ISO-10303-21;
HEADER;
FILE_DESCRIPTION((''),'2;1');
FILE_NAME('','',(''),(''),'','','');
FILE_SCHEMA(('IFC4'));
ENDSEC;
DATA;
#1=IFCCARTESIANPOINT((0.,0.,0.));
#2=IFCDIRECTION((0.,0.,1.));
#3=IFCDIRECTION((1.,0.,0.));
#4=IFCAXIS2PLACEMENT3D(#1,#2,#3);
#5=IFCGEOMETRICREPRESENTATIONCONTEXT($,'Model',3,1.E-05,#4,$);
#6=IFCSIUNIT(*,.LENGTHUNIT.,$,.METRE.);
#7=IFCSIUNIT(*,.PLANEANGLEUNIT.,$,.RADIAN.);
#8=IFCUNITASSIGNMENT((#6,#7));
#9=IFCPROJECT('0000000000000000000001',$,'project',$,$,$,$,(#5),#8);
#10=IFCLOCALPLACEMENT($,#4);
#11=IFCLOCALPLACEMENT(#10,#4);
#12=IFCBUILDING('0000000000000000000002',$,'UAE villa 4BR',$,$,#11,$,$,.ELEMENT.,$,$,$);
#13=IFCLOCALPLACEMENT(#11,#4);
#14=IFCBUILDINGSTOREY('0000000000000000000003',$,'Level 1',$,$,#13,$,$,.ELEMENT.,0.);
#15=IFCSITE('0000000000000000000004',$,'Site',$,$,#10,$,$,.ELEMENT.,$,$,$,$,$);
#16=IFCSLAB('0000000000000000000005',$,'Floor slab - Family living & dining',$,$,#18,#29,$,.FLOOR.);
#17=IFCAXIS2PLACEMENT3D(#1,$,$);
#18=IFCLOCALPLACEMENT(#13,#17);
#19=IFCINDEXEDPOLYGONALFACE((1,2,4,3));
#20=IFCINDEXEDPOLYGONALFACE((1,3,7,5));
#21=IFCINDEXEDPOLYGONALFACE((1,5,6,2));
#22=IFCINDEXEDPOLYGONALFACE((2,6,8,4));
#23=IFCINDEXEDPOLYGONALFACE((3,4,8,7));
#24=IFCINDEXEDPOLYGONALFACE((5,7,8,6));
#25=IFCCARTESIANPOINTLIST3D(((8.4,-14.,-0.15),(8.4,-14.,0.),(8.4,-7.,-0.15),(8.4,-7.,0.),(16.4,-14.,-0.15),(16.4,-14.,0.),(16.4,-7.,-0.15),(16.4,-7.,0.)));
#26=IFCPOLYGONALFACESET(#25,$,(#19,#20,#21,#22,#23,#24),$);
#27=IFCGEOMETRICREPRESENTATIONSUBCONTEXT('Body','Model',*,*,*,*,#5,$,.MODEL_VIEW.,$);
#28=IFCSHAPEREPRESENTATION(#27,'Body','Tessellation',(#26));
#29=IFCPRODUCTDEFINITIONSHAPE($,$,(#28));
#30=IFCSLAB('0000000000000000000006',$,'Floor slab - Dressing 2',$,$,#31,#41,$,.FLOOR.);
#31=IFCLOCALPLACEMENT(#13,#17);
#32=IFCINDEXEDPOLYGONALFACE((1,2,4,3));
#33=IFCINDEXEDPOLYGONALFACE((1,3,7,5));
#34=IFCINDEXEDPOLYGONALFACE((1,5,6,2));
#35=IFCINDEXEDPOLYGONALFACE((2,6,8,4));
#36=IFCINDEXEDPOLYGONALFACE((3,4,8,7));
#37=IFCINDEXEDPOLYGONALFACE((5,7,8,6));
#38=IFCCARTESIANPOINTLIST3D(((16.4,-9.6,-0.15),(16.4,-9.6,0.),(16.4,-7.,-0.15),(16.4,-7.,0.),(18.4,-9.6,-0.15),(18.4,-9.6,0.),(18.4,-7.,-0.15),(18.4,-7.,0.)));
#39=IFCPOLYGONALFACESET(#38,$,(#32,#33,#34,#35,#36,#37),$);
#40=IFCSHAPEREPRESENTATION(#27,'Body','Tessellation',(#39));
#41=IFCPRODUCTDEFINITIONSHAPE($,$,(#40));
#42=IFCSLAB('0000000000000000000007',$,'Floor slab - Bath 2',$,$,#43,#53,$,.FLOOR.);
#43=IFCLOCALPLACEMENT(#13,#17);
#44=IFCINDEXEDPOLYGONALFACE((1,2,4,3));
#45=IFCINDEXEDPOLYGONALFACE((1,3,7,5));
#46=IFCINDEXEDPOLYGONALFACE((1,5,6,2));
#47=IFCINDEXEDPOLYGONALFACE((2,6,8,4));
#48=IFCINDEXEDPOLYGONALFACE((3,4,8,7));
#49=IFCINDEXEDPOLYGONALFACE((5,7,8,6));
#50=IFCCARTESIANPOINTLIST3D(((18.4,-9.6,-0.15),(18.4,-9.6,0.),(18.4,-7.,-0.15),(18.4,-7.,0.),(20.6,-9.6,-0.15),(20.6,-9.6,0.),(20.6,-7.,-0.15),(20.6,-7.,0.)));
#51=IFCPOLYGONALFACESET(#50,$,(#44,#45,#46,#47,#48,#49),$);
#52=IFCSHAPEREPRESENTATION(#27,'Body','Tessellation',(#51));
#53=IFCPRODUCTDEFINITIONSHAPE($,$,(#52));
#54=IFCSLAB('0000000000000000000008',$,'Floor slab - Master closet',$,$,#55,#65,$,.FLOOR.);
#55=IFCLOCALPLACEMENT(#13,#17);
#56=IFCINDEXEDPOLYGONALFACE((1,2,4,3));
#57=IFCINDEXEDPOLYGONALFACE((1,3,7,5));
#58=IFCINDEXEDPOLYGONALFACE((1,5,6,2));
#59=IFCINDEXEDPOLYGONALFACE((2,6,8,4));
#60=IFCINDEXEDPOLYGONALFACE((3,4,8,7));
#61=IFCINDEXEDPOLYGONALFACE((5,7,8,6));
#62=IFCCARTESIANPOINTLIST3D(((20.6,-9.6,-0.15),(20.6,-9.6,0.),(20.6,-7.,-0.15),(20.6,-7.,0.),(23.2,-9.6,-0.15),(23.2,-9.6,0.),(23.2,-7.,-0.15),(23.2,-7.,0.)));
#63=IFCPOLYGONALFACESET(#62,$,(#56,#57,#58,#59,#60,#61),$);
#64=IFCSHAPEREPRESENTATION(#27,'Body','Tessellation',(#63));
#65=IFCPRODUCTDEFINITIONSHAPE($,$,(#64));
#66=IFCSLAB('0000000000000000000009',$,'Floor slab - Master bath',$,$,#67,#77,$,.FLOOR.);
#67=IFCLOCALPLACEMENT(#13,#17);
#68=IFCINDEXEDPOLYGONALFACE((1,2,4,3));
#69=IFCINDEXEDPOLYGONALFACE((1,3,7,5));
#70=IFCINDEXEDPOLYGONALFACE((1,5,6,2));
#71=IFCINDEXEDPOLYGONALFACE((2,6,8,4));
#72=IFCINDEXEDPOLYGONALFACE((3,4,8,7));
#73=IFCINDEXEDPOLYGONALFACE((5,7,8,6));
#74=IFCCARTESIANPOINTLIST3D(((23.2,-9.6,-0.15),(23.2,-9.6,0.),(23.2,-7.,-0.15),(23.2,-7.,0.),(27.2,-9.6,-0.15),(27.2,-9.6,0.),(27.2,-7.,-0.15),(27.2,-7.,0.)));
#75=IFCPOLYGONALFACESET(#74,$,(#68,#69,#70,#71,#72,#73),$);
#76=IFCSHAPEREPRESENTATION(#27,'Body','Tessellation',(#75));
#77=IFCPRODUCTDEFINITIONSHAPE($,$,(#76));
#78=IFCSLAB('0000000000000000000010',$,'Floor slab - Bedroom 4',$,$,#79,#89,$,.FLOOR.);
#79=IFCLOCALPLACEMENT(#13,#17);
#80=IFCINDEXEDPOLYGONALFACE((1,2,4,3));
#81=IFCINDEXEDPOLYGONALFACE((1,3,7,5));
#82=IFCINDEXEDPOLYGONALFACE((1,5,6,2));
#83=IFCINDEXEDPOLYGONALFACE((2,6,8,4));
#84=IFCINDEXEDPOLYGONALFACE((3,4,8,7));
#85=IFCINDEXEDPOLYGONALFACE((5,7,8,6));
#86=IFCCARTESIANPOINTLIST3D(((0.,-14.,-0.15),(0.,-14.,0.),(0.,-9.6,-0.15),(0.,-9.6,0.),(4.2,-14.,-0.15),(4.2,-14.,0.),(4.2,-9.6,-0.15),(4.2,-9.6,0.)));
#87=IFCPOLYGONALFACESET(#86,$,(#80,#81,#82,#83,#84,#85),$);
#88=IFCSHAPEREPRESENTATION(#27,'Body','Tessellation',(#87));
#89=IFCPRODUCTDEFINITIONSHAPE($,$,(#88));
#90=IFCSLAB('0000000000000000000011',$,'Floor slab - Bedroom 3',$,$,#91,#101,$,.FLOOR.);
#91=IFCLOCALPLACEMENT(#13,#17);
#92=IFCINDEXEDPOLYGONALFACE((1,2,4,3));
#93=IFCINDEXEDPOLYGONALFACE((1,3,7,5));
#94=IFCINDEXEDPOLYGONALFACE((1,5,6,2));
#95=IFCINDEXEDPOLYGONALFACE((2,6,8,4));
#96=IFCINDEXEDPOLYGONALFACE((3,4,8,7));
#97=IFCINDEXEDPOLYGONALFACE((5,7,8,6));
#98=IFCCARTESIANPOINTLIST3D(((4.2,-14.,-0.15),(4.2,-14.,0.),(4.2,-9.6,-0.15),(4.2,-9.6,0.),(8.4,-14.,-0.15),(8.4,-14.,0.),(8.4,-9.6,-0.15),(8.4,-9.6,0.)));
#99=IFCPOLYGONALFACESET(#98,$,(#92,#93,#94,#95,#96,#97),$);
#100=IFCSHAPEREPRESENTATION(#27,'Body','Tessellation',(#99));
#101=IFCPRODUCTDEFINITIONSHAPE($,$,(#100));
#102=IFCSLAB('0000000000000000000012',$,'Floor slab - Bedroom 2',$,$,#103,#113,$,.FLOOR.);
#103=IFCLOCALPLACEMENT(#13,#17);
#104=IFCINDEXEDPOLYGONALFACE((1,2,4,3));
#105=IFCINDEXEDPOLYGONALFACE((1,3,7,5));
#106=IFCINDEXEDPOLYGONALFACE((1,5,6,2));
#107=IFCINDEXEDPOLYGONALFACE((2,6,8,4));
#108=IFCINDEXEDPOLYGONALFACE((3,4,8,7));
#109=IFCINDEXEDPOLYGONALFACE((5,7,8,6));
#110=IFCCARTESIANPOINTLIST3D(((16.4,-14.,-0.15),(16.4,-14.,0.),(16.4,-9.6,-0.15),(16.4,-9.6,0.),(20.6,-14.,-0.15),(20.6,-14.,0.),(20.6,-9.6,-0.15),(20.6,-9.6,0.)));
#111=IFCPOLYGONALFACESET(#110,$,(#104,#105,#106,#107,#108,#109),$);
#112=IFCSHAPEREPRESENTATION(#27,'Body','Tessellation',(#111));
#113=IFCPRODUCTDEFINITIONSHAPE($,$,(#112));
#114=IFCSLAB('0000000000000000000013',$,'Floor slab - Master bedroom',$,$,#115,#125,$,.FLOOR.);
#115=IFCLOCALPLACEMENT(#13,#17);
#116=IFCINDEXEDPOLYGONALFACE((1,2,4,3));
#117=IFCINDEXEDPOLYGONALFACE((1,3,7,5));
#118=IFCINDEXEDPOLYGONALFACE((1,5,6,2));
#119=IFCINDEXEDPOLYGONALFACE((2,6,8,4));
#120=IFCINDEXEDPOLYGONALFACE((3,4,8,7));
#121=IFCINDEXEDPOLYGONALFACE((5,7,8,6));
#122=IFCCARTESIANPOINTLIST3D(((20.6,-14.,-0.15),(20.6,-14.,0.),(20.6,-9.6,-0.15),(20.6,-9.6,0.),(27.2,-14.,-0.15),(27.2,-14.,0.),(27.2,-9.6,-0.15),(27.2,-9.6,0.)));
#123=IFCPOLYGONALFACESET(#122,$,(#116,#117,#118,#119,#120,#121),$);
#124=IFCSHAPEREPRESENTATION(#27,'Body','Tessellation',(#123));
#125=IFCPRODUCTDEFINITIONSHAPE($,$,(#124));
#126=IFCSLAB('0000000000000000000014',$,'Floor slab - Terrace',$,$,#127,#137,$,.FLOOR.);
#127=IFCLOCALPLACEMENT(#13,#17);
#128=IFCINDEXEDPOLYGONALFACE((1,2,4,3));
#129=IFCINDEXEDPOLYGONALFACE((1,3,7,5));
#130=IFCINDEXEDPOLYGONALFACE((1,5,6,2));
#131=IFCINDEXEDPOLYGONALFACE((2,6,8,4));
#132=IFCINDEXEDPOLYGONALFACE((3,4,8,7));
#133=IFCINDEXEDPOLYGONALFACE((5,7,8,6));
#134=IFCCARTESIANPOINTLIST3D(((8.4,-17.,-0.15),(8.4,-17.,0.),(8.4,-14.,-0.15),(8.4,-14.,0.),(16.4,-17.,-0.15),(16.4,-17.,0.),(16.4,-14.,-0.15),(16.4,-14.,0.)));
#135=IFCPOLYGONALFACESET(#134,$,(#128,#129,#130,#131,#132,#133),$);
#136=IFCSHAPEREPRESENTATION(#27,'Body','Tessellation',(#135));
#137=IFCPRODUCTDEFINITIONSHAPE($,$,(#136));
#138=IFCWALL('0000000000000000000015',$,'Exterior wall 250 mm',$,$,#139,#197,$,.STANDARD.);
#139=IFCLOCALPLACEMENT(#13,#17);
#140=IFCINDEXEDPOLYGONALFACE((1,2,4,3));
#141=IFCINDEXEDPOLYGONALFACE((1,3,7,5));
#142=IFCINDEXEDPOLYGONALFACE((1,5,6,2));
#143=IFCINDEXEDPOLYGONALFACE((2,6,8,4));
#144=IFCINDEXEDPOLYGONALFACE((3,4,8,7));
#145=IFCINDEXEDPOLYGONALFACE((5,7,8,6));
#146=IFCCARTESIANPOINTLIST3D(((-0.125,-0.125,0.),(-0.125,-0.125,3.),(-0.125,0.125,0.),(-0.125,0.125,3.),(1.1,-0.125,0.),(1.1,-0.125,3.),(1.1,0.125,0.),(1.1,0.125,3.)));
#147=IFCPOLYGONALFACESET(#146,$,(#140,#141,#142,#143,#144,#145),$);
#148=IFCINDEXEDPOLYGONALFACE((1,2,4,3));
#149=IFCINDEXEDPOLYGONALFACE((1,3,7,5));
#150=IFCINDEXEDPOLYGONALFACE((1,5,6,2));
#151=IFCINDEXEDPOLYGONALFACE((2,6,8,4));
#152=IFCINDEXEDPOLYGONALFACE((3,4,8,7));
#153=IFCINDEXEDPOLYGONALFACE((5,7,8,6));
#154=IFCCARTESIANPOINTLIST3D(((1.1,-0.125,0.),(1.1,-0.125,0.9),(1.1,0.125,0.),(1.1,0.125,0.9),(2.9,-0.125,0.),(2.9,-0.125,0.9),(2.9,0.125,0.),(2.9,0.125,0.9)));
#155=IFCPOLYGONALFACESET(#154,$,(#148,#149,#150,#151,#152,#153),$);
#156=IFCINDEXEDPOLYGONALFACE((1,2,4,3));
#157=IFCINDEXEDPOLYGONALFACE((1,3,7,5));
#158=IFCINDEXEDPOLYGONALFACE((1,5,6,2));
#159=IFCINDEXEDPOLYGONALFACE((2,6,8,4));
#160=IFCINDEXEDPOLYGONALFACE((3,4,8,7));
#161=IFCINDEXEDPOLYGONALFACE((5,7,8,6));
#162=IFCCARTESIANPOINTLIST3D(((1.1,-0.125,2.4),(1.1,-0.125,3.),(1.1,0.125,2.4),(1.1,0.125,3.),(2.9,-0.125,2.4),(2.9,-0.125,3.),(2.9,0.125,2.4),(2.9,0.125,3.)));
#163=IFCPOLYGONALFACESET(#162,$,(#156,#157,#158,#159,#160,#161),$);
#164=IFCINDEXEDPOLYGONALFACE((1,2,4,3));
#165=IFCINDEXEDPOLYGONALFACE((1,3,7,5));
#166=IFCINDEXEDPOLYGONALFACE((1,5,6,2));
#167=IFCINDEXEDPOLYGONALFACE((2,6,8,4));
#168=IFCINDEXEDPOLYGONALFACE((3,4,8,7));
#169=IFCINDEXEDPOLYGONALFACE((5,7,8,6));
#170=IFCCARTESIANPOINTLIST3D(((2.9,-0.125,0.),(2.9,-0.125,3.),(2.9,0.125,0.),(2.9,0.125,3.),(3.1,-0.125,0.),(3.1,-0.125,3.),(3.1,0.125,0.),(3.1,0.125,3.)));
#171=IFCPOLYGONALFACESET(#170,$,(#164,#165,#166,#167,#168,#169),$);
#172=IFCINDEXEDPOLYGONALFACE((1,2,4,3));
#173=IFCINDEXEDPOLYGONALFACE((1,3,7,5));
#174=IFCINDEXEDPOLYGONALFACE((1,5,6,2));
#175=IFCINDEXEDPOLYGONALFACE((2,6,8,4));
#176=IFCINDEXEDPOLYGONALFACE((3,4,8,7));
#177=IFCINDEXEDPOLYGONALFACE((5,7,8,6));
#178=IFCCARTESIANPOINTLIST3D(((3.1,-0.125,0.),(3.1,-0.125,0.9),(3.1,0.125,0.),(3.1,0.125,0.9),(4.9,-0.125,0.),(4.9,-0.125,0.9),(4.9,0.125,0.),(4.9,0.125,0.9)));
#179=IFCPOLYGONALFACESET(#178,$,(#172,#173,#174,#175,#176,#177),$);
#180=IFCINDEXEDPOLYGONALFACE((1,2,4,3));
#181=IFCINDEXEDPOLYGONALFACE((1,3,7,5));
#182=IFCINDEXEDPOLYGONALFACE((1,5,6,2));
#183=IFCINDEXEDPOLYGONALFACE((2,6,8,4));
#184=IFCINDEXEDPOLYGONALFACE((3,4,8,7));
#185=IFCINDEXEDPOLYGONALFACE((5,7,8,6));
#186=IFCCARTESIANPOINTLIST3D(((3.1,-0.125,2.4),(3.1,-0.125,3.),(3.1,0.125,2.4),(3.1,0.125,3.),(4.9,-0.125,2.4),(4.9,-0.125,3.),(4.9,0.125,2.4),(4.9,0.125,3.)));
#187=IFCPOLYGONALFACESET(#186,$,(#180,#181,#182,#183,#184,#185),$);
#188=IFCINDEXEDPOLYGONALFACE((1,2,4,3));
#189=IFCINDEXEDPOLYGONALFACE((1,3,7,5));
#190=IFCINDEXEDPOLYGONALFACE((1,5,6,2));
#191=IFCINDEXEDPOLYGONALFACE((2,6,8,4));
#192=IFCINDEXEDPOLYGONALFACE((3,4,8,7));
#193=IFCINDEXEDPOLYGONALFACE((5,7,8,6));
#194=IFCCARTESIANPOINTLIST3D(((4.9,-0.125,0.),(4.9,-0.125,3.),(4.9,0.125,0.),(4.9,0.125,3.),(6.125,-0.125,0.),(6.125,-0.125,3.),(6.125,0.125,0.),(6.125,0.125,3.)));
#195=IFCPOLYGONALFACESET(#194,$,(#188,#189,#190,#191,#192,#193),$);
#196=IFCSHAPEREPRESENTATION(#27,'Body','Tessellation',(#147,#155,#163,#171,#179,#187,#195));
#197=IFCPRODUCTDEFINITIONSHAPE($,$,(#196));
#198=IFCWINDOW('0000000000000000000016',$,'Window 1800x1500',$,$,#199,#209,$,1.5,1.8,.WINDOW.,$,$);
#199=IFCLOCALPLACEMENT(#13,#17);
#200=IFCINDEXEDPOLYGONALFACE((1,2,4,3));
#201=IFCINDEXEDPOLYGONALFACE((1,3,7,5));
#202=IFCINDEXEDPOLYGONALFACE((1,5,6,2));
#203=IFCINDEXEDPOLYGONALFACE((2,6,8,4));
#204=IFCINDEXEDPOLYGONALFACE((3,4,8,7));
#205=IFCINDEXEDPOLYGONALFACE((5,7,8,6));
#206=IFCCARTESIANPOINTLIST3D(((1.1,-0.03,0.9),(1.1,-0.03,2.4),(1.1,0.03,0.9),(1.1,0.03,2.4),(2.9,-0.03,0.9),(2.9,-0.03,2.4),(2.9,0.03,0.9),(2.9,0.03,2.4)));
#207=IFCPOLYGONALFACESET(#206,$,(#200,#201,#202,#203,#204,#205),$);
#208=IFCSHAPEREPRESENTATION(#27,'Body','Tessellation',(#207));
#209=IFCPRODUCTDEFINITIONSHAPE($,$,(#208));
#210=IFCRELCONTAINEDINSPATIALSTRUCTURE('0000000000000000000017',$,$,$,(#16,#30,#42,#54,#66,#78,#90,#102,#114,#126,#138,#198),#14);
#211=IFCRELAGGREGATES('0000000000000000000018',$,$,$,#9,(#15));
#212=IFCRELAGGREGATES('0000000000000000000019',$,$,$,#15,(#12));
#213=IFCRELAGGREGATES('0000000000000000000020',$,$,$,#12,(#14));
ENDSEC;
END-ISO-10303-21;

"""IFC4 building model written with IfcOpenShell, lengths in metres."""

from ifc_helpers import new_model, si_unit, frame, origin, origin_with_axes, origin_2d, place, context, subcontext, project, spatial, polyline, rectangle, outline, extrude, element, save


model = new_model("IFC4")

# Units and contexts
model_context = context("Model", 3, precision=1e-05, world=origin_with_axes())
body_context = subcontext(model_context, "Body", "Model", "MODEL_VIEW")
ifc_project = project(units=[si_unit("LENGTHUNIT", "METRE"), si_unit("PLANEANGLEUNIT", "RADIAN")], contexts=[model_context])

# Site, building, storey
site_placement = place(None, origin_with_axes())
site = spatial("IfcSite", under=ifc_project, at=site_placement, Name="Site", CompositionType="ELEMENT")
building_placement = place(site_placement, origin_with_axes())
building = spatial("IfcBuilding", under=site, at=building_placement, Name="UAE villa 4BR", CompositionType="ELEMENT")
storey_placement = place(building_placement, origin_with_axes())
storey = spatial("IfcBuildingStorey", under=building, at=storey_placement, Name="Level 1", CompositionType="ELEMENT", Elevation=0.0)

# Slabs
slab_1_placement = place(storey_placement, frame((0.0, 0.0, -0.15), z_axis=(0.0, 0.0, 1.0), x_axis=(1.0, 0.0, 0.0)))
element("IfcSlab", 1, at=slab_1_placement, inside=storey, Name="Floor slab - Family living & dining", PredefinedType="FLOOR", context=body_context, shape_type="SweptSolid", body=[
    extrude(outline(polyline([(8.4, -7.0), (16.4, -7.0), (16.4, -14.0), (8.4, -14.0), (8.4, -7.0)])), origin(), (0.0, 0.0, 1.0), 0.15),
])
slab_2_placement = place(storey_placement, frame((0.0, 0.0, -0.15), z_axis=(0.0, 0.0, 1.0), x_axis=(1.0, 0.0, 0.0)))
element("IfcSlab", 2, at=slab_2_placement, inside=storey, Name="Floor slab - Dressing 2", PredefinedType="FLOOR", context=body_context, shape_type="SweptSolid", body=[
    extrude(outline(polyline([(16.4, -7.0), (18.4, -7.0), (18.4, -9.6), (16.4, -9.6), (16.4, -7.0)])), origin(), (0.0, 0.0, 1.0), 0.15),
])
slab_3_placement = place(storey_placement, frame((0.0, 0.0, -0.15), z_axis=(0.0, 0.0, 1.0), x_axis=(1.0, 0.0, 0.0)))
element("IfcSlab", 3, at=slab_3_placement, inside=storey, Name="Floor slab - Bath 2", PredefinedType="FLOOR", context=body_context, shape_type="SweptSolid", body=[
    extrude(outline(polyline([(18.4, -7.0), (20.6, -7.0), (20.6, -9.6), (18.4, -9.6), (18.4, -7.0)])), origin(), (0.0, 0.0, 1.0), 0.15),
])
slab_4_placement = place(storey_placement, frame((0.0, 0.0, -0.15), z_axis=(0.0, 0.0, 1.0), x_axis=(1.0, 0.0, 0.0)))
element("IfcSlab", 4, at=slab_4_placement, inside=storey, Name="Floor slab - Master closet", PredefinedType="FLOOR", context=body_context, shape_type="SweptSolid", body=[
    extrude(outline(polyline([(20.6, -7.0), (23.2, -7.0), (23.2, -9.6), (20.6, -9.6), (20.6, -7.0)])), origin(), (0.0, 0.0, 1.0), 0.15),
])
slab_5_placement = place(storey_placement, frame((0.0, 0.0, -0.15), z_axis=(0.0, 0.0, 1.0), x_axis=(1.0, 0.0, 0.0)))
element("IfcSlab", 5, at=slab_5_placement, inside=storey, Name="Floor slab - Master bath", PredefinedType="FLOOR", context=body_context, shape_type="SweptSolid", body=[
    extrude(outline(polyline([(23.2, -7.0), (27.2, -7.0), (27.2, -9.6), (23.2, -9.6), (23.2, -7.0)])), origin(), (0.0, 0.0, 1.0), 0.15),
])
slab_6_placement = place(storey_placement, frame((0.0, 0.0, -0.15), z_axis=(0.0, 0.0, 1.0), x_axis=(1.0, 0.0, 0.0)))
element("IfcSlab", 6, at=slab_6_placement, inside=storey, Name="Floor slab - Bedroom 4", PredefinedType="FLOOR", context=body_context, shape_type="SweptSolid", body=[
    extrude(outline(polyline([(0.0, -9.6), (4.2, -9.6), (4.2, -14.0), (0.0, -14.0), (0.0, -9.6)])), origin(), (0.0, 0.0, 1.0), 0.15),
])
slab_7_placement = place(storey_placement, frame((0.0, 0.0, -0.15), z_axis=(0.0, 0.0, 1.0), x_axis=(1.0, 0.0, 0.0)))
element("IfcSlab", 7, at=slab_7_placement, inside=storey, Name="Floor slab - Bedroom 3", PredefinedType="FLOOR", context=body_context, shape_type="SweptSolid", body=[
    extrude(outline(polyline([(4.2, -9.6), (8.4, -9.6), (8.4, -14.0), (4.2, -14.0), (4.2, -9.6)])), origin(), (0.0, 0.0, 1.0), 0.15),
])
slab_8_placement = place(storey_placement, frame((0.0, 0.0, -0.15), z_axis=(0.0, 0.0, 1.0), x_axis=(1.0, 0.0, 0.0)))
element("IfcSlab", 8, at=slab_8_placement, inside=storey, Name="Floor slab - Bedroom 2", PredefinedType="FLOOR", context=body_context, shape_type="SweptSolid", body=[
    extrude(outline(polyline([(16.4, -9.6), (20.6, -9.6), (20.6, -14.0), (16.4, -14.0), (16.4, -9.6)])), origin(), (0.0, 0.0, 1.0), 0.15),
])
slab_9_placement = place(storey_placement, frame((0.0, 0.0, -0.15), z_axis=(0.0, 0.0, 1.0), x_axis=(1.0, 0.0, 0.0)))
element("IfcSlab", 9, at=slab_9_placement, inside=storey, Name="Floor slab - Master bedroom", PredefinedType="FLOOR", context=body_context, shape_type="SweptSolid", body=[
    extrude(outline(polyline([(20.6, -9.6), (27.2, -9.6), (27.2, -14.0), (20.6, -14.0), (20.6, -9.6)])), origin(), (0.0, 0.0, 1.0), 0.15),
])
slab_10_placement = place(storey_placement, frame((0.0, 0.0, -0.15), z_axis=(0.0, 0.0, 1.0), x_axis=(1.0, 0.0, 0.0)))
element("IfcSlab", 10, at=slab_10_placement, inside=storey, Name="Floor slab - Terrace", PredefinedType="FLOOR", context=body_context, shape_type="SweptSolid", body=[
    extrude(outline(polyline([(8.4, -14.0), (16.4, -14.0), (16.4, -17.0), (8.4, -17.0), (8.4, -14.0)])), origin(), (0.0, 0.0, 1.0), 0.15),
])

# Wall
wall_placement = place(storey_placement, origin_with_axes())
element("IfcWall", 11, at=wall_placement, inside=storey, Name="Exterior wall 250 mm", PredefinedType="STANDARD", context=body_context, shape_type="SweptSolid", body=[
    extrude(rectangle(XDim=1.225, YDim=0.25, at=origin_2d()), frame((0.4875, 0.0, 0.0)), (0.0, 0.0, 1.0), 3.0),
    extrude(rectangle(XDim=1.8, YDim=0.25, at=origin_2d()), frame((2.0, 0.0, 0.0)), (0.0, 0.0, 1.0), 0.9),
    extrude(rectangle(XDim=1.8, YDim=0.25, at=origin_2d()), frame((2.0, 0.0, 2.4)), (0.0, 0.0, 1.0), 0.6),
    extrude(rectangle(XDim=0.2, YDim=0.25, at=origin_2d()), frame((3.0, 0.0, 0.0)), (0.0, 0.0, 1.0), 3.0),
    extrude(rectangle(XDim=1.8, YDim=0.25, at=origin_2d()), frame((4.0, 0.0, 0.0)), (0.0, 0.0, 1.0), 0.9),
    extrude(rectangle(XDim=1.8, YDim=0.25, at=origin_2d()), frame((4.0, 0.0, 2.4)), (0.0, 0.0, 1.0), 0.6),
    extrude(rectangle(XDim=1.225, YDim=0.25, at=origin_2d()), frame((5.5125, 0.0, 0.0)), (0.0, 0.0, 1.0), 3.0),
])

# Window
window_1_placement = place(storey_placement, frame((2.0, 0.0, 0.9), z_axis=(0.0, 0.0, 1.0), x_axis=(1.0, 0.0, 0.0)))
element("IfcWindow", 12, at=window_1_placement, inside=storey, Name="Window 1800x1500", OverallHeight=1.5, OverallWidth=1.8, PredefinedType="WINDOW", context=body_context, shape_type="SweptSolid", body=[
    extrude(rectangle(XDim=1.8, YDim=0.06, at=origin_2d()), origin(), (0.0, 0.0, 1.0), 1.5),
])

save(model, "model.ifc")
